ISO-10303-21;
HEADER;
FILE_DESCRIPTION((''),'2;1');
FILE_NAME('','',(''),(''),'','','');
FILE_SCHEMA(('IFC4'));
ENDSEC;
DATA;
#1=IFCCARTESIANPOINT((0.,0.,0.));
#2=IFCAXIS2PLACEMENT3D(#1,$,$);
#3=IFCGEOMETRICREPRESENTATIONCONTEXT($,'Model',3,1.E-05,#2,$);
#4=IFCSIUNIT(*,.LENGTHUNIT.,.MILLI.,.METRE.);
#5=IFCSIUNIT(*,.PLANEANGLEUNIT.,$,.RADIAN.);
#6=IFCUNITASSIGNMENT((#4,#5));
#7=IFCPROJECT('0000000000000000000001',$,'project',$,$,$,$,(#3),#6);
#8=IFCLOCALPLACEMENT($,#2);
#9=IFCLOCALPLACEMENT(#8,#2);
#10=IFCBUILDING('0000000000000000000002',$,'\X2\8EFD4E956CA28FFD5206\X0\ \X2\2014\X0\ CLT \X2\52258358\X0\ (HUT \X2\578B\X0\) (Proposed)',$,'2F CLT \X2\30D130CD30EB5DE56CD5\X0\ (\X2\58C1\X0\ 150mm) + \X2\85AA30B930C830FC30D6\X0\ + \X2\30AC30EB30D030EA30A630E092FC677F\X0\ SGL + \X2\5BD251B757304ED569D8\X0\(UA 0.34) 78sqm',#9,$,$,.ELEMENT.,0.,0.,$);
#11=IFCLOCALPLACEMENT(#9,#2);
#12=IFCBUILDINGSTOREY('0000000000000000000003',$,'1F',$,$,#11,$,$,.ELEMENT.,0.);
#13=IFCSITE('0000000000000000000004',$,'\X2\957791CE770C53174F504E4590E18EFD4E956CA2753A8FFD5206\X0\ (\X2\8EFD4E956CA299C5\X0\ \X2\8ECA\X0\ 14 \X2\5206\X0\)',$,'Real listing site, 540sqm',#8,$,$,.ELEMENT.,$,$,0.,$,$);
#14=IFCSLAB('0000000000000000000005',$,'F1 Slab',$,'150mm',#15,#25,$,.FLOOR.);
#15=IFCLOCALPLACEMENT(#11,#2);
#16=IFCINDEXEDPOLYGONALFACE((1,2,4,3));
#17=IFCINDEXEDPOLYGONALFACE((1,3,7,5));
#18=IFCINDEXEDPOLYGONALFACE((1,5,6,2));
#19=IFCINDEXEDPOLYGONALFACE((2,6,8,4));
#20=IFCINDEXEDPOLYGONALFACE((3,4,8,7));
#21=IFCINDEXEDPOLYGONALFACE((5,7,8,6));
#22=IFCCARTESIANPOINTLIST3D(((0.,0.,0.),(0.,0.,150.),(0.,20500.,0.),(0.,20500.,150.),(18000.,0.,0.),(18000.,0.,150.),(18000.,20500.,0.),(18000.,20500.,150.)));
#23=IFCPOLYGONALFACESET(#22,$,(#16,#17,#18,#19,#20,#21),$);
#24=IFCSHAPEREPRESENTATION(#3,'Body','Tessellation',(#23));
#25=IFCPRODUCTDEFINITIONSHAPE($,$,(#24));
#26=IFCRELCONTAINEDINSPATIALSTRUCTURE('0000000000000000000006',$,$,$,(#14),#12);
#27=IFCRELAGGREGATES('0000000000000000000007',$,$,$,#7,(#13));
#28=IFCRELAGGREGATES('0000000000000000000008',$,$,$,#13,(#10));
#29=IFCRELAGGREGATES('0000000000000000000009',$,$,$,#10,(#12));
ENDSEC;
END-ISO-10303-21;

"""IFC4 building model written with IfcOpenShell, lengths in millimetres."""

from ifc_helpers import new_model, si_unit, frame_2d, origin, place, context, project, spatial, rectangle, extrude, element, save


model = new_model("IFC4")

# Units and contexts
model_context = context("Model", 3, precision=1e-05, world=origin())
ifc_project = project(units=[si_unit("LENGTHUNIT", "METRE", prefix="MILLI"), si_unit("PLANEANGLEUNIT", "RADIAN")], contexts=[model_context])

# Site, building, storey
site_placement = place(None, origin())
site = spatial("IfcSite", under=ifc_project, at=site_placement, Name="長野県北佐久郡軽井沢町追分 (軽井沢駅 車 14 分)", ObjectType="Real listing site, 540sqm", CompositionType="ELEMENT", RefElevation=0.0)
building_placement = place(site_placement, origin())
building = spatial("IfcBuilding", under=site, at=building_placement, Name="軽井沢追分 — CLT 別荘 (HUT 型) (Proposed)", ObjectType="2F CLT パネル工法 (壁 150mm) + 薪ストーブ + ガルバリウム鋼板 SGL + 寒冷地仕様(UA 0.34) 78sqm", CompositionType="ELEMENT", ElevationOfRefHeight=0.0, ElevationOfTerrain=0.0)
storey_placement = place(building_placement, origin())
storey = spatial("IfcBuildingStorey", under=building, at=storey_placement, Name="1F", CompositionType="ELEMENT", Elevation=0.0)

# Slab
slab_placement = place(storey_placement, origin())
element("IfcSlab", 1, at=slab_placement, inside=storey, Name="F1 Slab", ObjectType="150mm", PredefinedType="FLOOR", context=model_context, shape_type="SweptSolid", body=[
    extrude(rectangle(XDim=18000.0, YDim=20500.0, at=frame_2d((9000.0, 10250.0))), origin(), (0.0, 0.0, 1.0), 150.0),
])

save(model, "model.ifc")
